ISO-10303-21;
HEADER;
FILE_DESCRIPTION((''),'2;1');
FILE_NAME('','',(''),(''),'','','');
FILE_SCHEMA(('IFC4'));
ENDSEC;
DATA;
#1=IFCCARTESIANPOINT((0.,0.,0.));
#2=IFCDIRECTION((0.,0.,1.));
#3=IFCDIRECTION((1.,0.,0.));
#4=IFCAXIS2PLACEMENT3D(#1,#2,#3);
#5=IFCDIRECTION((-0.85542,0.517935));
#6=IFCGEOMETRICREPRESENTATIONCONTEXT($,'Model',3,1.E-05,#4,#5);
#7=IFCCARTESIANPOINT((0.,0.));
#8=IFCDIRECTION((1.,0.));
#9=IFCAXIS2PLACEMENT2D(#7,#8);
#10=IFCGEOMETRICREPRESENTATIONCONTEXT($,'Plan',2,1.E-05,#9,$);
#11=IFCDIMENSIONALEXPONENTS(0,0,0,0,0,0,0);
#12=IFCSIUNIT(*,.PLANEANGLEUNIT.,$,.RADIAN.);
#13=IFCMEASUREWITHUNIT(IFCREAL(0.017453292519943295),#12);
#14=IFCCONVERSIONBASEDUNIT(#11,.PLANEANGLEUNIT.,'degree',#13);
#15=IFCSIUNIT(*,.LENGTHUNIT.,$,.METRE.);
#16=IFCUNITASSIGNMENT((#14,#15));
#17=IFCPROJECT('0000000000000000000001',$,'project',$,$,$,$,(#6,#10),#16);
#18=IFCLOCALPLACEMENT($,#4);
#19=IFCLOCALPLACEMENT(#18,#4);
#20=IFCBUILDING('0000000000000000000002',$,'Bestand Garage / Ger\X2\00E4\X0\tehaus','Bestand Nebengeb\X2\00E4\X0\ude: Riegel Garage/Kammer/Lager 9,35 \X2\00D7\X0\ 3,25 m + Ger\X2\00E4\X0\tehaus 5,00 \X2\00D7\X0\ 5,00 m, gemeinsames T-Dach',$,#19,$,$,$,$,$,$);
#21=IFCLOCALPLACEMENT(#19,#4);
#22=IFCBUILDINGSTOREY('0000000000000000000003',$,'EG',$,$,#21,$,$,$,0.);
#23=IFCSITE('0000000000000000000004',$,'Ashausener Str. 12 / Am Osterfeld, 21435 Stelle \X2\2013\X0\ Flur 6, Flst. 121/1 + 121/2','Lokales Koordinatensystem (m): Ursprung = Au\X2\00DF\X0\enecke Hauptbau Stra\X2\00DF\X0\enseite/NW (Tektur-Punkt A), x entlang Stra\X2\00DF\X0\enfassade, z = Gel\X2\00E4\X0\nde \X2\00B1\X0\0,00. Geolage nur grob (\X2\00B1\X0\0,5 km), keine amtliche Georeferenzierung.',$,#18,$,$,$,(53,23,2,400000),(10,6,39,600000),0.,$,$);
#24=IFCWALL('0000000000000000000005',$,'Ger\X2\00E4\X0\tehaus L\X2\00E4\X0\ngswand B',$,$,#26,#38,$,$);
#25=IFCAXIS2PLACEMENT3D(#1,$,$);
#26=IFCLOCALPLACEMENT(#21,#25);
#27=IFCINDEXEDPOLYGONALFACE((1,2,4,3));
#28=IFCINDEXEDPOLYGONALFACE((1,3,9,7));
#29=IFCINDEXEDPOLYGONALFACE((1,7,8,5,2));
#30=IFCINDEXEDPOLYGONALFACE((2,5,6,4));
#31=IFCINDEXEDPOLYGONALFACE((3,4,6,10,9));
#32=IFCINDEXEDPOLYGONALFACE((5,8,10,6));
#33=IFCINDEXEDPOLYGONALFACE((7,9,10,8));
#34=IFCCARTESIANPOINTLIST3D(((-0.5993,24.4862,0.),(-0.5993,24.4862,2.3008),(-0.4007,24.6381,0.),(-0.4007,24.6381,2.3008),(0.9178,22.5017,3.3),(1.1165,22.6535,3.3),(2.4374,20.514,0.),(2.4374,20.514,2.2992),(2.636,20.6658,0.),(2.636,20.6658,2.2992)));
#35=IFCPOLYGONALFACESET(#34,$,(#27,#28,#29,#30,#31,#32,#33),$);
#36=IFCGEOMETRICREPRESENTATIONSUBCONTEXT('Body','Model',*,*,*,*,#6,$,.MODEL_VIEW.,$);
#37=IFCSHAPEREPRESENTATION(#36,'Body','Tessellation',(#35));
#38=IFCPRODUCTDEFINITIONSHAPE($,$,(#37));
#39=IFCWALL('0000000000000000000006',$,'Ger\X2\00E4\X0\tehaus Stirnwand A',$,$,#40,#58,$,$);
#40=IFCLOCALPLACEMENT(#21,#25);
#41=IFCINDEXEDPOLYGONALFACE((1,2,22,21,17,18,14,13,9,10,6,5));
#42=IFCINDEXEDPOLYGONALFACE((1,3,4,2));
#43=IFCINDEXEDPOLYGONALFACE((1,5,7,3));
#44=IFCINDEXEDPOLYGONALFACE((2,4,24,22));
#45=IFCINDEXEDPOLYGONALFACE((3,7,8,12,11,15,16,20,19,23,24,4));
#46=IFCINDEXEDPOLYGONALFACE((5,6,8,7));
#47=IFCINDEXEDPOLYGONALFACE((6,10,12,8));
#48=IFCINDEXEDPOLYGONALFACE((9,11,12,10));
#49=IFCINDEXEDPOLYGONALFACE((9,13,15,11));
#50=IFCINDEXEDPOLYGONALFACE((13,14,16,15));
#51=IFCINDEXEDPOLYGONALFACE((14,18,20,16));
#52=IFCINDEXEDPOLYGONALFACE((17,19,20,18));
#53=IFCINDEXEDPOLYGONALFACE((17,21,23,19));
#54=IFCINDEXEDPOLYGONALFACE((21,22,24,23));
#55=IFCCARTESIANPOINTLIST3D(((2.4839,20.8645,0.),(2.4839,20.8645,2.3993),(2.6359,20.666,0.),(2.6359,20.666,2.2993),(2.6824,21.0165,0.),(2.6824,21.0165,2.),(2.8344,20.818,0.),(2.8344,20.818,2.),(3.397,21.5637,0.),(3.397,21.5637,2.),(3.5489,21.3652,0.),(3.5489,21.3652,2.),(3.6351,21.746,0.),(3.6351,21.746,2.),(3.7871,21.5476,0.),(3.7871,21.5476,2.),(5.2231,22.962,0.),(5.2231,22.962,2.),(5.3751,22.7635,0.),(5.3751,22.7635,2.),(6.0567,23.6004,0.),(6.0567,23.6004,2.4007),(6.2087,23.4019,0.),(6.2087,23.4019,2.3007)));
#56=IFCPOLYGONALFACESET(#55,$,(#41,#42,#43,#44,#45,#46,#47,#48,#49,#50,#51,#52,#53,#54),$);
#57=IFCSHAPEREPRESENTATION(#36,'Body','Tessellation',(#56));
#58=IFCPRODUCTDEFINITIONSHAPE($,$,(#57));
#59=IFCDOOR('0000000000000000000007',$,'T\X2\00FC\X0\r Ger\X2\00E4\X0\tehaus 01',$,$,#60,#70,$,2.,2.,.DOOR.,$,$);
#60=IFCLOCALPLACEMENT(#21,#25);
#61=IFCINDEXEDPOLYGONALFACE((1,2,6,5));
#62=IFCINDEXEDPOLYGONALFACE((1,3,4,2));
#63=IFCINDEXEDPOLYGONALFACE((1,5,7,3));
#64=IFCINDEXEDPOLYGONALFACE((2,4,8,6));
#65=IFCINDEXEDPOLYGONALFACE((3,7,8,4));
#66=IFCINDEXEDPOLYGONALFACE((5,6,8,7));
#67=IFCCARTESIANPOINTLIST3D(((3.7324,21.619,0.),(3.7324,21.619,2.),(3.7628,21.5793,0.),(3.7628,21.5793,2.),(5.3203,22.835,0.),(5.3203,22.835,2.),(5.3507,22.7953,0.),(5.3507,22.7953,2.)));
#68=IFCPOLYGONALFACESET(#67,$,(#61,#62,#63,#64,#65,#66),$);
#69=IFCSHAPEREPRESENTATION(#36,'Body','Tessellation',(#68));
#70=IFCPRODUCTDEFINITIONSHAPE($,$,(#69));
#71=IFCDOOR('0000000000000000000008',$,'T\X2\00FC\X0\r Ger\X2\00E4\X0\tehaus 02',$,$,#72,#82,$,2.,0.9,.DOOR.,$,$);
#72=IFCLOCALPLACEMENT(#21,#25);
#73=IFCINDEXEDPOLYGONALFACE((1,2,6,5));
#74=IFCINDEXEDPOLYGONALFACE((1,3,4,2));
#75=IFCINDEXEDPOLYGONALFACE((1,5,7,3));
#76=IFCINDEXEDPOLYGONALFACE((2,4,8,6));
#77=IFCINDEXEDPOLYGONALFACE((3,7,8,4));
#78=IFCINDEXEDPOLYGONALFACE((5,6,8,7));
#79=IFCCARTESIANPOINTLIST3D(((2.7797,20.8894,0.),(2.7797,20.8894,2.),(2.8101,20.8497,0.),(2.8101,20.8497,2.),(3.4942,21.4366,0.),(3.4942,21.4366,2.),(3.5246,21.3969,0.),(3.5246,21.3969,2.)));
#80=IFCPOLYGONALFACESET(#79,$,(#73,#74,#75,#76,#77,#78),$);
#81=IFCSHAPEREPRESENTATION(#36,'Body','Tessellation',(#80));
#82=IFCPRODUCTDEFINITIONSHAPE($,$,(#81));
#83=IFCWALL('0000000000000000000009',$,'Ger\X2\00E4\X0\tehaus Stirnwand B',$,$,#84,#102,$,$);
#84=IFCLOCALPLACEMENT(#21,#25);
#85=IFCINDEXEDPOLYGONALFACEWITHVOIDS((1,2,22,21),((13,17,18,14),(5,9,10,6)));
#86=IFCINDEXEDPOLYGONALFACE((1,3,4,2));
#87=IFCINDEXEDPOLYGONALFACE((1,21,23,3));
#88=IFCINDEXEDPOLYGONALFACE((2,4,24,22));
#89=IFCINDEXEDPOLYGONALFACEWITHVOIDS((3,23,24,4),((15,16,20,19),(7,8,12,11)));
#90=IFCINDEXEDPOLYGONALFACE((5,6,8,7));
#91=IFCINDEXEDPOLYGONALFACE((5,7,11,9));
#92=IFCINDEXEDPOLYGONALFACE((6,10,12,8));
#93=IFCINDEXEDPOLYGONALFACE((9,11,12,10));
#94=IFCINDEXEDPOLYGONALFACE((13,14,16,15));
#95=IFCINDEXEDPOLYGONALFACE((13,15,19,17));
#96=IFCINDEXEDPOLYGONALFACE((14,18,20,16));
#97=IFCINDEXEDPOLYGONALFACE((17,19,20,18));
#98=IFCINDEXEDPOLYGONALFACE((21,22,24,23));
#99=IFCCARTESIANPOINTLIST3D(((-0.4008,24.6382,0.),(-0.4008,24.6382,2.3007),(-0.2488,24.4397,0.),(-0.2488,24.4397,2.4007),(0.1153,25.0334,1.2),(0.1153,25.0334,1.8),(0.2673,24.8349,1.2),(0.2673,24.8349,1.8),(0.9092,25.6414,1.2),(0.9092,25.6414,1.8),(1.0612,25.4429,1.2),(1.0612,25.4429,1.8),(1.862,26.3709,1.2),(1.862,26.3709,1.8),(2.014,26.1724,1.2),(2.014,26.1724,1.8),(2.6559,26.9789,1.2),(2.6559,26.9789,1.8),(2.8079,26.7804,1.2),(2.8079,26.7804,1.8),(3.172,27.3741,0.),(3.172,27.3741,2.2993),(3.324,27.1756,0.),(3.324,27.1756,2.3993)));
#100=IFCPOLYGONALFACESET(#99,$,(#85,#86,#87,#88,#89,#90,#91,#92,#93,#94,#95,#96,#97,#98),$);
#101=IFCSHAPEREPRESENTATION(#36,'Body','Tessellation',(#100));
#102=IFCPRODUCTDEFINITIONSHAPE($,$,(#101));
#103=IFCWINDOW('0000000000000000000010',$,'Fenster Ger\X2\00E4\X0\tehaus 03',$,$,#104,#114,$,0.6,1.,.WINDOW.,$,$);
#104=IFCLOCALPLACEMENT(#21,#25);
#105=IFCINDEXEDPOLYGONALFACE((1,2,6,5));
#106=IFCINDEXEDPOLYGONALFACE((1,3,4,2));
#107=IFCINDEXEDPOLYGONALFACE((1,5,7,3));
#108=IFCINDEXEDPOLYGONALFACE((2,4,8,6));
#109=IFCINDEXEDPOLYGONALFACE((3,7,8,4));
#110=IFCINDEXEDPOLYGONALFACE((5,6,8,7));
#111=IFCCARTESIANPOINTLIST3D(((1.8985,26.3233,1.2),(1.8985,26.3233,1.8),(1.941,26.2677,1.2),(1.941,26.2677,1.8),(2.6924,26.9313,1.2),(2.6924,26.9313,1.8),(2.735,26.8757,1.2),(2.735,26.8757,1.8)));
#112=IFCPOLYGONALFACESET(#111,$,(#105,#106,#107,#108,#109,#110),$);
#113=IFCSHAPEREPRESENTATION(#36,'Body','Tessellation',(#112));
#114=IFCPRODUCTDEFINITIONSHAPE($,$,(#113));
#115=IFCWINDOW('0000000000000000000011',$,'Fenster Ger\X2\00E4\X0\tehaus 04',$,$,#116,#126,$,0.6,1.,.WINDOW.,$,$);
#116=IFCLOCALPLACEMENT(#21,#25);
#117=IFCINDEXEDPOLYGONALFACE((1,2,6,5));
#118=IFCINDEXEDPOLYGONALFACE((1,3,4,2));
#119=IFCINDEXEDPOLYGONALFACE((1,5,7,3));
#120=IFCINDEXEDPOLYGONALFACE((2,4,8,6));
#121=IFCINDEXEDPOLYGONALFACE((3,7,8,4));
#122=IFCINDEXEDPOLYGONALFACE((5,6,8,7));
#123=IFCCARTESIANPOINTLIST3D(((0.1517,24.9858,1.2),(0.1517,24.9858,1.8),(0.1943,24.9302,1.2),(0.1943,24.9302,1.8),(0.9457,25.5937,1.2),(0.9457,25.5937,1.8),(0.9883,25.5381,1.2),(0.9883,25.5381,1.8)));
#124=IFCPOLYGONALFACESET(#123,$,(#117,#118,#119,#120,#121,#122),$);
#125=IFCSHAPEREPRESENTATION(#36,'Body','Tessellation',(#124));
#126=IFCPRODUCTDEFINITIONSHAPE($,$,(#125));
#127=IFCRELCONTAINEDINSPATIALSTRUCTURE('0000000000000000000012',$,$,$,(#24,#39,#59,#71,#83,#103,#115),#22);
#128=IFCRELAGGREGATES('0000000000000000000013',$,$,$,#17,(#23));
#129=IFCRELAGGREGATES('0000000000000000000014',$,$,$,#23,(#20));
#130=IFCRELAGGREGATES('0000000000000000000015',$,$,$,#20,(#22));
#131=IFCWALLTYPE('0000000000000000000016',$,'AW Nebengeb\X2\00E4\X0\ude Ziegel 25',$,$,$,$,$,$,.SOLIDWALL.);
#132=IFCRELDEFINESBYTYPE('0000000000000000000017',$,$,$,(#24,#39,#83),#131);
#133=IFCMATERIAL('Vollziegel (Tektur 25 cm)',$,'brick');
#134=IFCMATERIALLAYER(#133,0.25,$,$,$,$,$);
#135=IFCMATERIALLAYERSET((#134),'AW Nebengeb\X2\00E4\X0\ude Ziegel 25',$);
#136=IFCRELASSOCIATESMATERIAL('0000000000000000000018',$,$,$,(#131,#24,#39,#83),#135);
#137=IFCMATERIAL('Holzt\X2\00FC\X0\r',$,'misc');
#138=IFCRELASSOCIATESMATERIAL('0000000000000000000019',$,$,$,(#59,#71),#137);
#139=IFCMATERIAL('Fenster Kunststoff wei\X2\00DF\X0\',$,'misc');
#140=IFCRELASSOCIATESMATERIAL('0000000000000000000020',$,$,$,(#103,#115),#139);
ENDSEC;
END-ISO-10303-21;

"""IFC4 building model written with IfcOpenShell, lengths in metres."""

from ifc_helpers import new_model, entity, si_unit, converted_unit, direction, frame, origin_with_axes, origin_2d_with_axis, place, context, subcontext, project, spatial, indexed_curve, outline, extrude, clip, halfspace, material, layer, layer_set, layer_usage, type_object, element, fill, save


model = new_model("IFC4")

# Units and contexts
model_context = context("Model", 3, precision=1e-05, world=origin_with_axes(), true_north=direction((-0.85542, 0.517935)))
plan_context = context("Plan", 2, precision=1e-05, world=origin_2d_with_axis())
body_context = subcontext(model_context, "Body", "Model", "MODEL_VIEW")
ifc_project = project(units=[converted_unit("PLANEANGLEUNIT", "degree", entity("IfcReal", 0.017453292519943295), si_unit("PLANEANGLEUNIT", "RADIAN"), dimensions=[0, 0, 0, 0, 0, 0, 0]), si_unit("LENGTHUNIT", "METRE")], contexts=[model_context, plan_context])

# Site, building, storey
site_placement = place(None, origin_with_axes())
site = spatial("IfcSite", under=ifc_project, at=site_placement, Name="Ashausener Str. 12 / Am Osterfeld, 21435 Stelle – Flur 6, Flst. 121/1 + 121/2", Description="Lokales Koordinatensystem (m): Ursprung = Außenecke Hauptbau Straßenseite/NW (Tektur-Punkt A), x entlang Straßenfassade, z = Gelände ±0,00. Geolage nur grob (±0,5 km), keine amtliche Georeferenzierung.", RefLatitude=(53, 23, 2, 400000), RefLongitude=(10, 6, 39, 600000), RefElevation=0.0)
building_placement = place(site_placement, origin_with_axes())
building = spatial("IfcBuilding", under=site, at=building_placement, Name="Bestand Garage / Gerätehaus", Description="Bestand Nebengebäude: Riegel Garage/Kammer/Lager 9,35 × 3,25 m + Gerätehaus 5,00 × 5,00 m, gemeinsames T-Dach")
storey_placement = place(building_placement, origin_with_axes())
storey = spatial("IfcBuildingStorey", under=building, at=storey_placement, Name="EG", Elevation=0.0)

# Shared definitions
ifc_material_1 = material(Name="Vollziegel (Tektur 25 cm)", Category="brick")
ifc_layer_1 = layer(ifc_material_1, 0.25)
ifc_layer_set_1 = layer_set([ifc_layer_1], Name="AW Nebengebäude Ziegel 25")
wall_type = type_object("IfcWallType", Name="AW Nebengebäude Ziegel 25", PredefinedType="SOLIDWALL", material=ifc_layer_set_1)

# Wall
ifc_layer_usage_1 = layer_usage(ifc_layer_set_1, "AXIS2", "POSITIVE", 0.0)
wall_1_placement = place(storey_placement, frame((-0.5993, 24.4862, 0.0), z_axis=(0.0, 0.0, 1.0), x_axis=(0.607339, -0.794443, 0.0)))
element("IfcWall", 1, at=wall_1_placement, inside=storey, type_object=wall_type, material=ifc_layer_usage_1, Name="Gerätehaus Längswand B", context=body_context, shape_type="Clipping", body=[
    clip(clip(extrude(outline(indexed_curve([(0.0, 0.0), (0.0, 0.25), (5.0, 0.25), (5.0, 0.0), (0.0, 0.0)], self_intersect=False)), origin_with_axes(), (0.0, 0.0, 1.0), 6.0), halfspace(frame((-0.002, 2.5, 2.3), z_axis=(-0.37139, 0.0, 0.92848), x_axis=(0.0, 1.0, 0.0)), False)), halfspace(frame((4.998, 2.5, 2.3), z_axis=(0.37139, 0.0, 0.92848), x_axis=(0.0, -1.0, 0.0)), False)),
])

# Wall, openings, doors
ifc_layer_usage_2 = layer_usage(ifc_layer_set_1, "AXIS2", "POSITIVE", 0.0)
wall_2_placement = place(storey_placement, frame((2.6359, 20.666, 0.0), z_axis=(0.0, 0.0, 1.0), x_axis=(0.79396, 0.60797, 0.0)))
wall_2 = element("IfcWall", 2, at=wall_2_placement, inside=storey, type_object=wall_type, material=ifc_layer_usage_2, Name="Gerätehaus Stirnwand A", context=body_context, shape_type="Clipping", body=[
    clip(clip(extrude(outline(indexed_curve([(0.0, 0.0), (0.0, 0.25), (4.5, 0.25), (4.5, 0.0), (0.0, 0.0)], self_intersect=False)), origin_with_axes(), (0.0, 0.0, 1.0), 6.0), halfspace(frame((2.254, 5.0, 2.3), z_axis=(0.000295, 0.37139, 0.92848), x_axis=(1.0, -0.000795, 0.0)), False)), halfspace(frame((2.25, 0.0, 2.3), z_axis=(-0.000295, -0.37139, 0.92848), x_axis=(-1.0, 0.000795, 0.0)), False)),
])
opening_1_placement = place(wall_2_placement, frame((1.45, -0.1, 0.0), z_axis=(0.0, 0.0, 1.0), x_axis=(1.0, 0.0, 0.0)))
opening_1 = element("IfcOpeningElement", 3, at=opening_1_placement, cuts=wall_2, context=body_context, shape_type="SweptSolid", body=[
    extrude(outline(indexed_curve([(0.0, 0.0), (0.0, 0.45), (2.0, 0.45), (2.0, 0.0), (0.0, 0.0)], self_intersect=False)), origin_with_axes(), (0.0, 0.0, 1.0), 2.0),
])
opening_2_placement = place(wall_2_placement, frame((0.25, -0.1, 0.0), z_axis=(0.0, 0.0, 1.0), x_axis=(1.0, 0.0, 0.0)))
opening_2 = element("IfcOpeningElement", 4, at=opening_2_placement, cuts=wall_2, context=body_context, shape_type="SweptSolid", body=[
    extrude(outline(indexed_curve([(0.0, 0.0), (0.0, 0.45), (0.9, 0.45), (0.9, 0.0), (0.0, 0.0)], self_intersect=False)), origin_with_axes(), (0.0, 0.0, 1.0), 2.0),
])
ifc_material_2 = material(Name="Holztür", Category="misc")
door_1_placement = place(storey_placement, frame((3.7628, 21.5793, 0.0), z_axis=(0.0, 0.0, 1.0), x_axis=(0.79396, 0.60797, 0.0)))
door_1 = element("IfcDoor", 5, at=door_1_placement, inside=storey, material=ifc_material_2, Name="Tür Gerätehaus 01", OverallHeight=2.0, OverallWidth=2.0, PredefinedType="DOOR", context=body_context, shape_type="SweptSolid", body=[
    extrude(outline(indexed_curve([(0.0, 0.0), (0.0, 0.05), (2.0, 0.05), (2.0, 0.0), (0.0, 0.0)], self_intersect=False)), origin_with_axes(), (0.0, 0.0, 1.0), 2.0),
])
fill(opening_1, door_1)
door_2_placement = place(storey_placement, frame((2.8101, 20.8497, 0.0), z_axis=(0.0, 0.0, 1.0), x_axis=(0.79396, 0.60797, 0.0)))
door_2 = element("IfcDoor", 6, at=door_2_placement, inside=storey, material=ifc_material_2, Name="Tür Gerätehaus 02", OverallHeight=2.0, OverallWidth=0.9, PredefinedType="DOOR", context=body_context, shape_type="SweptSolid", body=[
    extrude(outline(indexed_curve([(0.0, 0.0), (0.0, 0.05), (0.9, 0.05), (0.9, 0.0), (0.0, 0.0)], self_intersect=False)), origin_with_axes(), (0.0, 0.0, 1.0), 2.0),
])
fill(opening_2, door_2)

# Wall, openings, windows
ifc_layer_usage_3 = layer_usage(ifc_layer_set_1, "AXIS2", "POSITIVE", 0.0)
wall_3_placement = place(storey_placement, frame((3.172, 27.3741, 0.0), z_axis=(0.0, 0.0, 1.0), x_axis=(-0.79396, -0.60797, 0.0)))
wall_3 = element("IfcWall", 7, at=wall_3_placement, inside=storey, type_object=wall_type, material=ifc_layer_usage_3, Name="Gerätehaus Stirnwand B", context=body_context, shape_type="Clipping", body=[
    clip(clip(extrude(outline(indexed_curve([(0.0, 0.0), (0.0, 0.25), (4.5, 0.25), (4.5, 0.0), (0.0, 0.0)], self_intersect=False)), origin_with_axes(), (0.0, 0.0, 1.0), 6.0), halfspace(frame((2.25, 0.0, 2.3), z_axis=(-0.000295, -0.37139, 0.92848), x_axis=(-1.0, 0.000795, 0.0)), False)), halfspace(frame((2.254, 5.0, 2.3), z_axis=(0.000295, 0.37139, 0.92848), x_axis=(1.0, -0.000795, 0.0)), False)),
])
opening_3_placement = place(wall_3_placement, frame((0.65, -0.1, 1.2), z_axis=(0.0, 0.0, 1.0), x_axis=(1.0, 0.0, 0.0)))
opening_3 = element("IfcOpeningElement", 8, at=opening_3_placement, cuts=wall_3, context=body_context, shape_type="SweptSolid", body=[
    extrude(outline(indexed_curve([(0.0, 0.0), (0.0, 0.45), (1.0, 0.45), (1.0, 0.0), (0.0, 0.0)], self_intersect=False)), origin_with_axes(), (0.0, 0.0, 1.0), 0.6),
])
opening_4_placement = place(wall_3_placement, frame((2.85, -0.1, 1.2), z_axis=(0.0, 0.0, 1.0), x_axis=(1.0, 0.0, 0.0)))
opening_4 = element("IfcOpeningElement", 9, at=opening_4_placement, cuts=wall_3, context=body_context, shape_type="SweptSolid", body=[
    extrude(outline(indexed_curve([(0.0, 0.0), (0.0, 0.45), (1.0, 0.45), (1.0, 0.0), (0.0, 0.0)], self_intersect=False)), origin_with_axes(), (0.0, 0.0, 1.0), 0.6),
])
ifc_material_3 = material(Name="Fenster Kunststoff weiß", Category="misc")
window_1_placement = place(storey_placement, frame((2.6924, 26.9313, 1.2), z_axis=(0.0, 0.0, 1.0), x_axis=(-0.79396, -0.60797, 0.0)))
window_1 = element("IfcWindow", 10, at=window_1_placement, inside=storey, material=ifc_material_3, Name="Fenster Gerätehaus 03", OverallHeight=0.6, OverallWidth=1.0, PredefinedType="WINDOW", context=body_context, shape_type="SweptSolid", body=[
    extrude(outline(indexed_curve([(0.0, 0.0), (0.0, 0.07), (1.0, 0.07), (1.0, 0.0), (0.0, 0.0)], self_intersect=False)), origin_with_axes(), (0.0, 0.0, 1.0), 0.6),
])
fill(opening_3, window_1)
window_2_placement = place(storey_placement, frame((0.9457, 25.5937, 1.2), z_axis=(0.0, 0.0, 1.0), x_axis=(-0.79396, -0.60797, 0.0)))
window_2 = element("IfcWindow", 11, at=window_2_placement, inside=storey, material=ifc_material_3, Name="Fenster Gerätehaus 04", OverallHeight=0.6, OverallWidth=1.0, PredefinedType="WINDOW", context=body_context, shape_type="SweptSolid", body=[
    extrude(outline(indexed_curve([(0.0, 0.0), (0.0, 0.07), (1.0, 0.07), (1.0, 0.0), (0.0, 0.0)], self_intersect=False)), origin_with_axes(), (0.0, 0.0, 1.0), 0.6),
])
fill(opening_4, window_2)

save(model, "model.ifc")
